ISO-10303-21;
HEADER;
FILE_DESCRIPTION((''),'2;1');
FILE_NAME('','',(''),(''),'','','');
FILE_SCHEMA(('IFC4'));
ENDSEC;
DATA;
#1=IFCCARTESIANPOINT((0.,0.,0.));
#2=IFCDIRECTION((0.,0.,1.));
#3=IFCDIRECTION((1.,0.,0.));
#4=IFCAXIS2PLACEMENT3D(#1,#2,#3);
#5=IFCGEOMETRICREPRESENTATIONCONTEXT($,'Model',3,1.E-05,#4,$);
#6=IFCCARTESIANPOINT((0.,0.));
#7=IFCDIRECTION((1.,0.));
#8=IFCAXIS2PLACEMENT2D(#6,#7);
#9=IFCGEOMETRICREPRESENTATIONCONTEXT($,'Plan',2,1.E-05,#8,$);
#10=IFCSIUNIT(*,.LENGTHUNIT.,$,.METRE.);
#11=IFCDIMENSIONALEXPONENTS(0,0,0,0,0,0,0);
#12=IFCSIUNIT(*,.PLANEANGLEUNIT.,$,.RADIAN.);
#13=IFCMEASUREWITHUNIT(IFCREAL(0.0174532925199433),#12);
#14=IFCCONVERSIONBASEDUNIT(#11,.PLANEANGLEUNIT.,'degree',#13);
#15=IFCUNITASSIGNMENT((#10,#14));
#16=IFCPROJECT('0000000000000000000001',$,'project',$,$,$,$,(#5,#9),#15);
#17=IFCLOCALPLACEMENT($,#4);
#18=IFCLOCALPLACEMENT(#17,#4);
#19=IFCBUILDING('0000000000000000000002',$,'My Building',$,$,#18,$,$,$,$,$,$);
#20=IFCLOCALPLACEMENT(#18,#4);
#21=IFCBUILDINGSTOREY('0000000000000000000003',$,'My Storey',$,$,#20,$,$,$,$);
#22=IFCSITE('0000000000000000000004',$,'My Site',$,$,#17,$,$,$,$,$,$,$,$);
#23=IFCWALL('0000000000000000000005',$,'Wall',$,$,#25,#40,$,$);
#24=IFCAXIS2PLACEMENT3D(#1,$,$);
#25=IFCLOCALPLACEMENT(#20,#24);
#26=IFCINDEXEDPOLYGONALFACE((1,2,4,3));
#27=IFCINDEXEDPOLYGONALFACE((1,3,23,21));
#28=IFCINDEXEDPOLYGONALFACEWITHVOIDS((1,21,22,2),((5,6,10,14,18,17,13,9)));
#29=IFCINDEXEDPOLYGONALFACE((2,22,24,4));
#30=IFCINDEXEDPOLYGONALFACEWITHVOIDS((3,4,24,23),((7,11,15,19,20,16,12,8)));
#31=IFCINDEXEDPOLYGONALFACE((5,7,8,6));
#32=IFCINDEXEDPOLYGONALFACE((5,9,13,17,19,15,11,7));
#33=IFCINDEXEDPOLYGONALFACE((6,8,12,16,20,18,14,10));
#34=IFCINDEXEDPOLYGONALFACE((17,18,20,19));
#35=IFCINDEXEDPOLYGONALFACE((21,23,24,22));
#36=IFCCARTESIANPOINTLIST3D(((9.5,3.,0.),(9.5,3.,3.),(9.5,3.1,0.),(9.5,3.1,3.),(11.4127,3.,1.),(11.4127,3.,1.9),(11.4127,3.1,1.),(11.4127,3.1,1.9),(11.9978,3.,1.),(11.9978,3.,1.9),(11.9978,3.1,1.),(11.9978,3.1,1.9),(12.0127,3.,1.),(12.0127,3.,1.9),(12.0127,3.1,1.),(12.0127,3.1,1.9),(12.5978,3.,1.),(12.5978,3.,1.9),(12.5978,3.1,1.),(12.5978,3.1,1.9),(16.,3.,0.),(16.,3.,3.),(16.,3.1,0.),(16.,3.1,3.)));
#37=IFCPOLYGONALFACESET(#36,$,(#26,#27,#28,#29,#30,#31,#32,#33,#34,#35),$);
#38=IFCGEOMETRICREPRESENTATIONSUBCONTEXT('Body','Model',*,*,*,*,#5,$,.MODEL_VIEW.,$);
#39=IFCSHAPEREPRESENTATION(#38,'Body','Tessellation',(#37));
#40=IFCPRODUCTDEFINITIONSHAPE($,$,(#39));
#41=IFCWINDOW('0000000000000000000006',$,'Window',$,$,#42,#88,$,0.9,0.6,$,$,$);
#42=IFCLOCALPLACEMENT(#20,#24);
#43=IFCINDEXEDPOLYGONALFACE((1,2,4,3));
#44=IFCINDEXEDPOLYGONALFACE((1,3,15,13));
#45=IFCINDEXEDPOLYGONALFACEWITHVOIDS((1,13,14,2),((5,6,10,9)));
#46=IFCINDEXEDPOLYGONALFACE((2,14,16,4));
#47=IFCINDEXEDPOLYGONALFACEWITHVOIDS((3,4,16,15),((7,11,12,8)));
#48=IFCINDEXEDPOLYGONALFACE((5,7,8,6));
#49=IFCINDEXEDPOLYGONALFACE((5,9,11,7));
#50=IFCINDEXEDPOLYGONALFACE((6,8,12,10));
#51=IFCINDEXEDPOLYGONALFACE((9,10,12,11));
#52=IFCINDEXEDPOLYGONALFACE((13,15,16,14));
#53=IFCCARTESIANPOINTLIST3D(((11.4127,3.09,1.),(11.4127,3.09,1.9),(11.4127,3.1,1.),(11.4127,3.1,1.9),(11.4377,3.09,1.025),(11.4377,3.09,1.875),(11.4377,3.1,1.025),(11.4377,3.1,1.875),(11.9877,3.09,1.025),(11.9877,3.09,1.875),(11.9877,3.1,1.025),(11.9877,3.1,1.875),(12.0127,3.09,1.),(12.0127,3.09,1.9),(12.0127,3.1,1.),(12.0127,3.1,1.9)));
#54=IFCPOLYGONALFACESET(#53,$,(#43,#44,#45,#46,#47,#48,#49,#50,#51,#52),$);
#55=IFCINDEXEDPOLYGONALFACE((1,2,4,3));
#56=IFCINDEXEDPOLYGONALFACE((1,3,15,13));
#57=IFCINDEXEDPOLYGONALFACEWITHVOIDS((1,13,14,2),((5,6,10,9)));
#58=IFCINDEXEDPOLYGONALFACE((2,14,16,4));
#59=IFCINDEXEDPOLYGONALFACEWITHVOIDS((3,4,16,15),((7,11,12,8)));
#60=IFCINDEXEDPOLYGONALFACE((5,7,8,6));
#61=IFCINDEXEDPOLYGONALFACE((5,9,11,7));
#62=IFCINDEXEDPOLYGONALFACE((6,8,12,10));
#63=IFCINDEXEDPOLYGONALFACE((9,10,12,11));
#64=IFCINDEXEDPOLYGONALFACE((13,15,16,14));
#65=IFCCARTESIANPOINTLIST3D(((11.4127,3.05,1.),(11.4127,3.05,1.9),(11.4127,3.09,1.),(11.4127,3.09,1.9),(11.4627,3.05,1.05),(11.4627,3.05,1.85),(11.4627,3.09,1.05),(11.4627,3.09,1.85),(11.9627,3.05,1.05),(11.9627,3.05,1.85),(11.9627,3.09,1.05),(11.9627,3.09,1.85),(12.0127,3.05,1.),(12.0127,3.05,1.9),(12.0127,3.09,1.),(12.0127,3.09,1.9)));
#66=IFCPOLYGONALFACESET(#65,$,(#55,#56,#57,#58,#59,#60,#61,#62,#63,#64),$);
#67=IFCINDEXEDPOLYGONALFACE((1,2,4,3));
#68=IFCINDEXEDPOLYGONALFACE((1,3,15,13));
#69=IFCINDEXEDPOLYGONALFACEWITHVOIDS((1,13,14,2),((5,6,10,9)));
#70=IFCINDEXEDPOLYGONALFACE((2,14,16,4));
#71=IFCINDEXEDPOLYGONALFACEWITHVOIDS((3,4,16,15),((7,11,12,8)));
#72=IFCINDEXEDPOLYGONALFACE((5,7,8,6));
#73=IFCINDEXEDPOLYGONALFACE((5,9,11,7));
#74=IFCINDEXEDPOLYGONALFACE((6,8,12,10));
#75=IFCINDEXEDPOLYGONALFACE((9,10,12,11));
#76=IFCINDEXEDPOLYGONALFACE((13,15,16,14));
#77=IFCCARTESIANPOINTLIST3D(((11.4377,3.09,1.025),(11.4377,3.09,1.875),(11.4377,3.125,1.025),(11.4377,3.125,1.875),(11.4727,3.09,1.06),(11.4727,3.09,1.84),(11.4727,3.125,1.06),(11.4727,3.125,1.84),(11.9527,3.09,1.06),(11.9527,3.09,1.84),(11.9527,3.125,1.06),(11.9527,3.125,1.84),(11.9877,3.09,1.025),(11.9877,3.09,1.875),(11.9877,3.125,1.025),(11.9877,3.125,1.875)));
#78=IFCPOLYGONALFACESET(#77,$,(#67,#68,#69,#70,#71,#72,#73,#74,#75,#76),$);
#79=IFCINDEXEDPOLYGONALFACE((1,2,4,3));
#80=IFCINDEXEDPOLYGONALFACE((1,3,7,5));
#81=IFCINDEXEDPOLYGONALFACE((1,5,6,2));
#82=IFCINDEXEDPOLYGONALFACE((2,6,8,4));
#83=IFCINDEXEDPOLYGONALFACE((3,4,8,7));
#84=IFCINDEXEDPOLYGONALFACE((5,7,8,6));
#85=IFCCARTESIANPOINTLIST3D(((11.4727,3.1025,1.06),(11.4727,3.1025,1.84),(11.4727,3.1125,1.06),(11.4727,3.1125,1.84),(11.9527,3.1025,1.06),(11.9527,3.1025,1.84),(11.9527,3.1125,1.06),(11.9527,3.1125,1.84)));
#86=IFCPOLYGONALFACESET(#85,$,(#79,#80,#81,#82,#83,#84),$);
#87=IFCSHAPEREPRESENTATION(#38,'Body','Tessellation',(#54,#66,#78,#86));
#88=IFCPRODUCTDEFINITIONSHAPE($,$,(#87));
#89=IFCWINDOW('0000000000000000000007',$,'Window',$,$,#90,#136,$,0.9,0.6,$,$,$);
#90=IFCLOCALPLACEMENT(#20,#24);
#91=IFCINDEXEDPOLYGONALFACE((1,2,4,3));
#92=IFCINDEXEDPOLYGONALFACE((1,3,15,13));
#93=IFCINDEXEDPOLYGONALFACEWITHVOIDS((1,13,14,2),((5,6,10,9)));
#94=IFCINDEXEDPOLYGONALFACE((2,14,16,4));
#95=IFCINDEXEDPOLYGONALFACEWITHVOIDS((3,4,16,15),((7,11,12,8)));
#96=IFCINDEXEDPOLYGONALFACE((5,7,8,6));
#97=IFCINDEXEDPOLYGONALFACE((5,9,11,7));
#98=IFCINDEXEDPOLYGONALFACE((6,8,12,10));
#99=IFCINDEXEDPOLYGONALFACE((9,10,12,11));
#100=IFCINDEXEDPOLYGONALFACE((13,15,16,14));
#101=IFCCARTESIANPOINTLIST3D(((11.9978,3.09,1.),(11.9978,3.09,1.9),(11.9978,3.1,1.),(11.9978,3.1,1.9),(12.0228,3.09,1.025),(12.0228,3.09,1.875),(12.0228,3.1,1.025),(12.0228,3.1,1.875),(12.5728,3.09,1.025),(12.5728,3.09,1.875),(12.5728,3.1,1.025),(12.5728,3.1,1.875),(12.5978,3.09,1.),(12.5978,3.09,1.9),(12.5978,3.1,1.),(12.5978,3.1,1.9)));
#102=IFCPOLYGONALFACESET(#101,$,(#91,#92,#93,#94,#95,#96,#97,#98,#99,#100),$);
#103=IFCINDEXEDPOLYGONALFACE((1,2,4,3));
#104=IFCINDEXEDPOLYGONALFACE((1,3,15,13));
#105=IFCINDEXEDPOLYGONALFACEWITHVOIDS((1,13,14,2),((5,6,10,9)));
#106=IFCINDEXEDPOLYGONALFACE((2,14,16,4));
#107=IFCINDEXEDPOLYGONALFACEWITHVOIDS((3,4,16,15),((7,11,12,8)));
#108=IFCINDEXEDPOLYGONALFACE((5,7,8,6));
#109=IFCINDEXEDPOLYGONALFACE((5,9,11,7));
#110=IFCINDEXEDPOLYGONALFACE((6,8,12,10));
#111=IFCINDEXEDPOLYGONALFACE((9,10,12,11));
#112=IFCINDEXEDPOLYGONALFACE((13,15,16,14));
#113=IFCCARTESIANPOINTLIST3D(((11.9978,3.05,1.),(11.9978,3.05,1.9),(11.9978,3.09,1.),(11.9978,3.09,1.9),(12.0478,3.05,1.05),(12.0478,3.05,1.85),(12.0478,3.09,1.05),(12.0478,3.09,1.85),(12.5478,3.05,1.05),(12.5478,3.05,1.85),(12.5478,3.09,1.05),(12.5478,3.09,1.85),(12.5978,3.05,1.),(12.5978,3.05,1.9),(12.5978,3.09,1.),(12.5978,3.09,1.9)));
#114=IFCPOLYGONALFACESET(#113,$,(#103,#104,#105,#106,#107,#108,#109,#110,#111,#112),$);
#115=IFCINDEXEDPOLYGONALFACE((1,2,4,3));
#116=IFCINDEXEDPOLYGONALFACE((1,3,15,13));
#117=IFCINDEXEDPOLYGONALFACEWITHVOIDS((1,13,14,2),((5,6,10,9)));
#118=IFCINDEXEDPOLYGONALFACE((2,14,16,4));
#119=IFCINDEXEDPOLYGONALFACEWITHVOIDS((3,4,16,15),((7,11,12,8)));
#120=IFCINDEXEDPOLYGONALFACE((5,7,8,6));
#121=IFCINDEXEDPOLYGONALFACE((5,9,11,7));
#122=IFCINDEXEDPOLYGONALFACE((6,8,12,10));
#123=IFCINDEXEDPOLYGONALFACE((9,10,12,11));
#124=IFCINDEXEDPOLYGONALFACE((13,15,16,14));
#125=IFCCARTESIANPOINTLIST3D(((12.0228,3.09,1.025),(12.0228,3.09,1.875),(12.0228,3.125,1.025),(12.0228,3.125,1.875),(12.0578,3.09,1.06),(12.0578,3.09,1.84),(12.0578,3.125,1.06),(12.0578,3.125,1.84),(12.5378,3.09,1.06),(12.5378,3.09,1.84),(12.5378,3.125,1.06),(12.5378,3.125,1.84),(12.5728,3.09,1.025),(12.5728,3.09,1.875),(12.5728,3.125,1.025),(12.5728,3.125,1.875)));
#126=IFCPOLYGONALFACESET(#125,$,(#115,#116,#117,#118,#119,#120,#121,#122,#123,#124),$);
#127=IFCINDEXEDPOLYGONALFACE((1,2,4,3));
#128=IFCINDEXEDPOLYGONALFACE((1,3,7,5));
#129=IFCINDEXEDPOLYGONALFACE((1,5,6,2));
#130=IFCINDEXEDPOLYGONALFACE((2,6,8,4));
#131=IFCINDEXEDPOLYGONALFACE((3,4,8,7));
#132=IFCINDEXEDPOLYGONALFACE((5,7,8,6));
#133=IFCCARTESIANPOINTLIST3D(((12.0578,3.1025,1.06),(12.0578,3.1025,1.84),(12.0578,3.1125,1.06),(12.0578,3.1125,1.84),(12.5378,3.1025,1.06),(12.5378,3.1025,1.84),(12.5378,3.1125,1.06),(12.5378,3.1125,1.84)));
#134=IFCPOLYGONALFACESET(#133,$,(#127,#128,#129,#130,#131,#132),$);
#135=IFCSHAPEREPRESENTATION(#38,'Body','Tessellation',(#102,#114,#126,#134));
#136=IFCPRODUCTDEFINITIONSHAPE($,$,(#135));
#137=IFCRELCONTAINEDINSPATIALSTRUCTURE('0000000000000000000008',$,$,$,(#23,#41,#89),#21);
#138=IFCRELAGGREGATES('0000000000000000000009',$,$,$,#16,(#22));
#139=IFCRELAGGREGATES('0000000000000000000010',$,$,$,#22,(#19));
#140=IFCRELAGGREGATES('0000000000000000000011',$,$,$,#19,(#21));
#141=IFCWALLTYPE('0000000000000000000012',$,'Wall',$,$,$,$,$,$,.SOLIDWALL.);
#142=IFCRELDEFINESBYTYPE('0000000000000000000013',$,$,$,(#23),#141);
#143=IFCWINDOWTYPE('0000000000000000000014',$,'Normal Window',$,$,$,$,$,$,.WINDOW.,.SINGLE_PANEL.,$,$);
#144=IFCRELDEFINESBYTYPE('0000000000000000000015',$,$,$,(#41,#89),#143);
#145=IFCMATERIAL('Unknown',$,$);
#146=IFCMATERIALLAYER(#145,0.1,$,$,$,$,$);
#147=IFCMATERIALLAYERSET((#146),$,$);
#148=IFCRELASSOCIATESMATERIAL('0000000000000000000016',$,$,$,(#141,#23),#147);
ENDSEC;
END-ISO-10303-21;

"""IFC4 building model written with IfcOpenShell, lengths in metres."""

from ifc_helpers import new_model, entity, si_unit, converted_unit, frame, origin_with_axes, origin_2d_with_axis, place, context, subcontext, project, spatial, line, indexed_curve, outline, extrude, shape, source, transform, mapped, material, layer, layer_set, layer_usage, type_object, type_shapes, element, fill, save


model = new_model("IFC4")

# Units and contexts
model_context = context("Model", 3, precision=1e-05, world=origin_with_axes())
plan_context = context("Plan", 2, precision=1e-05, world=origin_2d_with_axis())
body_context_1 = subcontext(model_context, "Body", "Model", "MODEL_VIEW")
body_context_2 = subcontext(plan_context, "Body", "Plan", "PLAN_VIEW")
ifc_project = project(units=[si_unit("LENGTHUNIT", "METRE"), converted_unit("PLANEANGLEUNIT", "degree", entity("IfcReal", 0.0174532925199433), si_unit("PLANEANGLEUNIT", "RADIAN"), dimensions=[0, 0, 0, 0, 0, 0, 0])], contexts=[model_context, plan_context])

# Site, building, storey
site_placement = place(None, origin_with_axes())
site = spatial("IfcSite", under=ifc_project, at=site_placement, Name="My Site")
building_placement = place(site_placement, origin_with_axes())
building = spatial("IfcBuilding", under=site, at=building_placement, Name="My Building")
storey_placement = place(building_placement, origin_with_axes())
storey = spatial("IfcBuildingStorey", under=building, at=storey_placement, Name="My Storey")

# Shared definitions
ifc_material = material(Name="Unknown")

# Shared definitions
ifc_layer = layer(ifc_material, 0.1)
ifc_layer_set = layer_set([ifc_layer])
wall_type = type_object("IfcWallType", Name="Wall", PredefinedType="SOLIDWALL", material=ifc_layer_set)

# Wall, openings, windows
ifc_layer_usage_1 = layer_usage(ifc_layer_set, "AXIS2", "POSITIVE", 0.0)
wall_1_placement = place(storey_placement, frame((9.5, 3.0, 0.0), z_axis=(0.0, 0.0, 1.0), x_axis=(1.0, 0.0, 0.0)))
wall_1 = element("IfcWall", 1, at=wall_1_placement, inside=storey, type_object=wall_type, material=ifc_layer_usage_1, Name="Wall", context=body_context_1, shape_type="SweptSolid", body=[
    extrude(outline(indexed_curve([(0.0, 0.0), (0.0, 0.1), (6.5, 0.1), (6.5, 0.0)], segments=[line(1, 2, 3, 4, 1)])), origin_with_axes(), (0.0, 0.0, 1.0), 3.0),
])
shared_shape_1 = source(origin_with_axes(), body_context_1, "Body", "SweptSolid", [
    extrude(outline(indexed_curve([(0.0, 0.0), (0.6, 0.0), (0.6, 0.9), (0.0, 0.9)], segments=[line(1, 2, 3, 4, 1)])), frame((0.0, -0.6, 0.0), z_axis=(0.0, -1.0, 0.0), x_axis=(1.0, 0.0, 0.0)), (0.0, 0.0, -1.0), 1.2),
])
opening_1_placement = place(wall_1_placement, frame((1.9127, 0.0, 1.0), z_axis=(0.0, 0.0, 1.0), x_axis=(1.0, 0.0, 0.0)))
opening_1 = element("IfcOpeningElement", 2, at=opening_1_placement, cuts=wall_1, PredefinedType="OPENING", context=body_context_1, shape_type="MappedRepresentation", body=[
    mapped(shared_shape_1, transform((0.0, 0.0, 0.0), x_axis=(1.0, 0.0, 0.0), y_axis=(0.0, 1.0, 0.0), z_axis=(0.0, 0.0, 1.0), scale=1.0)),
])
opening_2_placement = place(wall_1_placement, frame((2.4978, 0.0, 1.0), z_axis=(0.0, 0.0, 1.0), x_axis=(1.0, 0.0, 0.0)))
opening_2 = element("IfcOpeningElement", 3, at=opening_2_placement, cuts=wall_1, PredefinedType="OPENING", context=body_context_1, shape_type="MappedRepresentation", body=[
    mapped(shared_shape_1, transform((0.0, 0.0, 0.0), x_axis=(1.0, 0.0, 0.0), y_axis=(0.0, 1.0, 0.0), z_axis=(0.0, 0.0, 1.0), scale=1.0)),
])
window_type = type_object("IfcWindowType", Name="Normal Window", PartitioningType="SINGLE_PANEL", PredefinedType="WINDOW")
shared_shape_2 = source(origin_with_axes(), body_context_1, "Body", "SweptSolid", [
    extrude(outline(indexed_curve([(0.0, 0.0), (0.6, 0.0), (0.6, 0.9), (0.0, 0.9)], segments=[line(1, 2, 3, 4, 1)]), holes=[indexed_curve([(0.025, 0.025), (0.575, 0.025), (0.575, 0.875), (0.025, 0.875)], segments=[line(1, 2, 3, 4, 1)])]), frame((0.0, 0.09, 0.0), z_axis=(0.0, -1.0, 0.0), x_axis=(1.0, 0.0, 0.0)), (0.0, 0.0, -1.0), 0.01),
    extrude(outline(indexed_curve([(0.0, 0.0), (0.6, 0.0), (0.6, 0.9), (0.0, 0.9)], segments=[line(1, 2, 3, 4, 1)]), holes=[indexed_curve([(0.05, 0.05), (0.55, 0.05), (0.55, 0.85), (0.05, 0.85)], segments=[line(1, 2, 3, 4, 1)])]), frame((0.0, 0.05, 0.0), z_axis=(0.0, -1.0, 0.0), x_axis=(1.0, 0.0, 0.0)), (0.0, 0.0, -1.0), 0.04),
    extrude(outline(indexed_curve([(0.0, 0.0), (0.55, 0.0), (0.55, 0.85), (0.0, 0.85)], segments=[line(1, 2, 3, 4, 1)]), holes=[indexed_curve([(0.035, 0.035), (0.515, 0.035), (0.515, 0.815), (0.035, 0.815)], segments=[line(1, 2, 3, 4, 1)])]), frame((0.025, 0.09, 0.025), z_axis=(0.0, -1.0, 0.0), x_axis=(1.0, 0.0, 0.0)), (0.0, 0.0, -1.0), 0.035),
    extrude(outline(indexed_curve([(0.035, 0.035), (0.515, 0.035), (0.515, 0.815), (0.035, 0.815)], segments=[line(1, 2, 3, 4, 1)])), frame((0.025, 0.1025, 0.025), z_axis=(0.0, -1.0, 0.0), x_axis=(1.0, 0.0, 0.0)), (0.0, 0.0, -1.0), 0.01),
])
shared_shape_3 = source(origin_with_axes(), body_context_2, "Body", "Curve2D", [
    entity("IfcIndexedPolyCurve", entity("IfcCartesianPointList2D", [[0.05, 0.05], [0.55, 0.05]])),
    entity("IfcIndexedPolyCurve", entity("IfcCartesianPointList2D", [[0.0, 0.1], [0.025, 0.1], [0.025, 0.09], [0.05, 0.09], [0.05, 0.05], [0.0, 0.05]]), [entity("IfcLineIndex", [1, 2, 3, 4, 5, 6, 1])]),
    entity("IfcIndexedPolyCurve", entity("IfcCartesianPointList2D", [[0.6, 0.1], [0.575, 0.1], [0.575, 0.09], [0.55, 0.09], [0.55, 0.05], [0.6, 0.05]]), [entity("IfcLineIndex", [1, 2, 3, 4, 5, 6, 1])]),
    entity("IfcIndexedPolyCurve", entity("IfcCartesianPointList2D", [[0.025, 0.09], [0.06, 0.09], [0.06, 0.125], [0.025, 0.125]]), [entity("IfcLineIndex", [1, 2, 3, 4, 1])]),
    entity("IfcIndexedPolyCurve", entity("IfcCartesianPointList2D", [[0.575, 0.09], [0.54, 0.09], [0.54, 0.125], [0.575, 0.125]]), [entity("IfcLineIndex", [1, 2, 3, 4, 1])]),
    entity("IfcIndexedPolyCurve", entity("IfcCartesianPointList2D", [[0.06, 0.09], [0.54, 0.09]])),
    entity("IfcIndexedPolyCurve", entity("IfcCartesianPointList2D", [[0.06, 0.125], [0.54, 0.125]])),
    entity("IfcIndexedPolyCurve", entity("IfcCartesianPointList2D", [[0.06, 0.1075], [0.54, 0.1075]])),
])
type_shapes(window_type, [shared_shape_2, shared_shape_3])
window_1_placement = place(opening_1_placement, origin_with_axes())
window_1 = element("IfcWindow", 4, at=window_1_placement, inside=storey, type_object=window_type, Name="Window", OverallHeight=0.9, OverallWidth=0.6, shapes=[
    shape(body_context_1, "Body", "MappedRepresentation", [mapped(shared_shape_2, transform((0.0, 0.0, 0.0), x_axis=(1.0, 0.0, 0.0), y_axis=(0.0, 1.0, 0.0), z_axis=(0.0, 0.0, 1.0), scale=1.0))]),
    shape(body_context_2, "Body", "MappedRepresentation", [mapped(shared_shape_3, transform((0.0, 0.0, 0.0), x_axis=(1.0, 0.0, 0.0), y_axis=(0.0, 1.0, 0.0), z_axis=(0.0, 0.0, 1.0), scale=1.0))]),
])
fill(opening_1, window_1)
window_2_placement = place(opening_2_placement, origin_with_axes())
window_2 = element("IfcWindow", 5, at=window_2_placement, inside=storey, type_object=window_type, Name="Window", OverallHeight=0.9, OverallWidth=0.6, shapes=[
    shape(body_context_1, "Body", "MappedRepresentation", [mapped(shared_shape_2, transform((0.0, 0.0, 0.0), x_axis=(1.0, 0.0, 0.0), y_axis=(0.0, 1.0, 0.0), z_axis=(0.0, 0.0, 1.0), scale=1.0))]),
    shape(body_context_2, "Body", "MappedRepresentation", [mapped(shared_shape_3, transform((0.0, 0.0, 0.0), x_axis=(1.0, 0.0, 0.0), y_axis=(0.0, 1.0, 0.0), z_axis=(0.0, 0.0, 1.0), scale=1.0))]),
])
fill(opening_2, window_2)

save(model, "model.ifc")
